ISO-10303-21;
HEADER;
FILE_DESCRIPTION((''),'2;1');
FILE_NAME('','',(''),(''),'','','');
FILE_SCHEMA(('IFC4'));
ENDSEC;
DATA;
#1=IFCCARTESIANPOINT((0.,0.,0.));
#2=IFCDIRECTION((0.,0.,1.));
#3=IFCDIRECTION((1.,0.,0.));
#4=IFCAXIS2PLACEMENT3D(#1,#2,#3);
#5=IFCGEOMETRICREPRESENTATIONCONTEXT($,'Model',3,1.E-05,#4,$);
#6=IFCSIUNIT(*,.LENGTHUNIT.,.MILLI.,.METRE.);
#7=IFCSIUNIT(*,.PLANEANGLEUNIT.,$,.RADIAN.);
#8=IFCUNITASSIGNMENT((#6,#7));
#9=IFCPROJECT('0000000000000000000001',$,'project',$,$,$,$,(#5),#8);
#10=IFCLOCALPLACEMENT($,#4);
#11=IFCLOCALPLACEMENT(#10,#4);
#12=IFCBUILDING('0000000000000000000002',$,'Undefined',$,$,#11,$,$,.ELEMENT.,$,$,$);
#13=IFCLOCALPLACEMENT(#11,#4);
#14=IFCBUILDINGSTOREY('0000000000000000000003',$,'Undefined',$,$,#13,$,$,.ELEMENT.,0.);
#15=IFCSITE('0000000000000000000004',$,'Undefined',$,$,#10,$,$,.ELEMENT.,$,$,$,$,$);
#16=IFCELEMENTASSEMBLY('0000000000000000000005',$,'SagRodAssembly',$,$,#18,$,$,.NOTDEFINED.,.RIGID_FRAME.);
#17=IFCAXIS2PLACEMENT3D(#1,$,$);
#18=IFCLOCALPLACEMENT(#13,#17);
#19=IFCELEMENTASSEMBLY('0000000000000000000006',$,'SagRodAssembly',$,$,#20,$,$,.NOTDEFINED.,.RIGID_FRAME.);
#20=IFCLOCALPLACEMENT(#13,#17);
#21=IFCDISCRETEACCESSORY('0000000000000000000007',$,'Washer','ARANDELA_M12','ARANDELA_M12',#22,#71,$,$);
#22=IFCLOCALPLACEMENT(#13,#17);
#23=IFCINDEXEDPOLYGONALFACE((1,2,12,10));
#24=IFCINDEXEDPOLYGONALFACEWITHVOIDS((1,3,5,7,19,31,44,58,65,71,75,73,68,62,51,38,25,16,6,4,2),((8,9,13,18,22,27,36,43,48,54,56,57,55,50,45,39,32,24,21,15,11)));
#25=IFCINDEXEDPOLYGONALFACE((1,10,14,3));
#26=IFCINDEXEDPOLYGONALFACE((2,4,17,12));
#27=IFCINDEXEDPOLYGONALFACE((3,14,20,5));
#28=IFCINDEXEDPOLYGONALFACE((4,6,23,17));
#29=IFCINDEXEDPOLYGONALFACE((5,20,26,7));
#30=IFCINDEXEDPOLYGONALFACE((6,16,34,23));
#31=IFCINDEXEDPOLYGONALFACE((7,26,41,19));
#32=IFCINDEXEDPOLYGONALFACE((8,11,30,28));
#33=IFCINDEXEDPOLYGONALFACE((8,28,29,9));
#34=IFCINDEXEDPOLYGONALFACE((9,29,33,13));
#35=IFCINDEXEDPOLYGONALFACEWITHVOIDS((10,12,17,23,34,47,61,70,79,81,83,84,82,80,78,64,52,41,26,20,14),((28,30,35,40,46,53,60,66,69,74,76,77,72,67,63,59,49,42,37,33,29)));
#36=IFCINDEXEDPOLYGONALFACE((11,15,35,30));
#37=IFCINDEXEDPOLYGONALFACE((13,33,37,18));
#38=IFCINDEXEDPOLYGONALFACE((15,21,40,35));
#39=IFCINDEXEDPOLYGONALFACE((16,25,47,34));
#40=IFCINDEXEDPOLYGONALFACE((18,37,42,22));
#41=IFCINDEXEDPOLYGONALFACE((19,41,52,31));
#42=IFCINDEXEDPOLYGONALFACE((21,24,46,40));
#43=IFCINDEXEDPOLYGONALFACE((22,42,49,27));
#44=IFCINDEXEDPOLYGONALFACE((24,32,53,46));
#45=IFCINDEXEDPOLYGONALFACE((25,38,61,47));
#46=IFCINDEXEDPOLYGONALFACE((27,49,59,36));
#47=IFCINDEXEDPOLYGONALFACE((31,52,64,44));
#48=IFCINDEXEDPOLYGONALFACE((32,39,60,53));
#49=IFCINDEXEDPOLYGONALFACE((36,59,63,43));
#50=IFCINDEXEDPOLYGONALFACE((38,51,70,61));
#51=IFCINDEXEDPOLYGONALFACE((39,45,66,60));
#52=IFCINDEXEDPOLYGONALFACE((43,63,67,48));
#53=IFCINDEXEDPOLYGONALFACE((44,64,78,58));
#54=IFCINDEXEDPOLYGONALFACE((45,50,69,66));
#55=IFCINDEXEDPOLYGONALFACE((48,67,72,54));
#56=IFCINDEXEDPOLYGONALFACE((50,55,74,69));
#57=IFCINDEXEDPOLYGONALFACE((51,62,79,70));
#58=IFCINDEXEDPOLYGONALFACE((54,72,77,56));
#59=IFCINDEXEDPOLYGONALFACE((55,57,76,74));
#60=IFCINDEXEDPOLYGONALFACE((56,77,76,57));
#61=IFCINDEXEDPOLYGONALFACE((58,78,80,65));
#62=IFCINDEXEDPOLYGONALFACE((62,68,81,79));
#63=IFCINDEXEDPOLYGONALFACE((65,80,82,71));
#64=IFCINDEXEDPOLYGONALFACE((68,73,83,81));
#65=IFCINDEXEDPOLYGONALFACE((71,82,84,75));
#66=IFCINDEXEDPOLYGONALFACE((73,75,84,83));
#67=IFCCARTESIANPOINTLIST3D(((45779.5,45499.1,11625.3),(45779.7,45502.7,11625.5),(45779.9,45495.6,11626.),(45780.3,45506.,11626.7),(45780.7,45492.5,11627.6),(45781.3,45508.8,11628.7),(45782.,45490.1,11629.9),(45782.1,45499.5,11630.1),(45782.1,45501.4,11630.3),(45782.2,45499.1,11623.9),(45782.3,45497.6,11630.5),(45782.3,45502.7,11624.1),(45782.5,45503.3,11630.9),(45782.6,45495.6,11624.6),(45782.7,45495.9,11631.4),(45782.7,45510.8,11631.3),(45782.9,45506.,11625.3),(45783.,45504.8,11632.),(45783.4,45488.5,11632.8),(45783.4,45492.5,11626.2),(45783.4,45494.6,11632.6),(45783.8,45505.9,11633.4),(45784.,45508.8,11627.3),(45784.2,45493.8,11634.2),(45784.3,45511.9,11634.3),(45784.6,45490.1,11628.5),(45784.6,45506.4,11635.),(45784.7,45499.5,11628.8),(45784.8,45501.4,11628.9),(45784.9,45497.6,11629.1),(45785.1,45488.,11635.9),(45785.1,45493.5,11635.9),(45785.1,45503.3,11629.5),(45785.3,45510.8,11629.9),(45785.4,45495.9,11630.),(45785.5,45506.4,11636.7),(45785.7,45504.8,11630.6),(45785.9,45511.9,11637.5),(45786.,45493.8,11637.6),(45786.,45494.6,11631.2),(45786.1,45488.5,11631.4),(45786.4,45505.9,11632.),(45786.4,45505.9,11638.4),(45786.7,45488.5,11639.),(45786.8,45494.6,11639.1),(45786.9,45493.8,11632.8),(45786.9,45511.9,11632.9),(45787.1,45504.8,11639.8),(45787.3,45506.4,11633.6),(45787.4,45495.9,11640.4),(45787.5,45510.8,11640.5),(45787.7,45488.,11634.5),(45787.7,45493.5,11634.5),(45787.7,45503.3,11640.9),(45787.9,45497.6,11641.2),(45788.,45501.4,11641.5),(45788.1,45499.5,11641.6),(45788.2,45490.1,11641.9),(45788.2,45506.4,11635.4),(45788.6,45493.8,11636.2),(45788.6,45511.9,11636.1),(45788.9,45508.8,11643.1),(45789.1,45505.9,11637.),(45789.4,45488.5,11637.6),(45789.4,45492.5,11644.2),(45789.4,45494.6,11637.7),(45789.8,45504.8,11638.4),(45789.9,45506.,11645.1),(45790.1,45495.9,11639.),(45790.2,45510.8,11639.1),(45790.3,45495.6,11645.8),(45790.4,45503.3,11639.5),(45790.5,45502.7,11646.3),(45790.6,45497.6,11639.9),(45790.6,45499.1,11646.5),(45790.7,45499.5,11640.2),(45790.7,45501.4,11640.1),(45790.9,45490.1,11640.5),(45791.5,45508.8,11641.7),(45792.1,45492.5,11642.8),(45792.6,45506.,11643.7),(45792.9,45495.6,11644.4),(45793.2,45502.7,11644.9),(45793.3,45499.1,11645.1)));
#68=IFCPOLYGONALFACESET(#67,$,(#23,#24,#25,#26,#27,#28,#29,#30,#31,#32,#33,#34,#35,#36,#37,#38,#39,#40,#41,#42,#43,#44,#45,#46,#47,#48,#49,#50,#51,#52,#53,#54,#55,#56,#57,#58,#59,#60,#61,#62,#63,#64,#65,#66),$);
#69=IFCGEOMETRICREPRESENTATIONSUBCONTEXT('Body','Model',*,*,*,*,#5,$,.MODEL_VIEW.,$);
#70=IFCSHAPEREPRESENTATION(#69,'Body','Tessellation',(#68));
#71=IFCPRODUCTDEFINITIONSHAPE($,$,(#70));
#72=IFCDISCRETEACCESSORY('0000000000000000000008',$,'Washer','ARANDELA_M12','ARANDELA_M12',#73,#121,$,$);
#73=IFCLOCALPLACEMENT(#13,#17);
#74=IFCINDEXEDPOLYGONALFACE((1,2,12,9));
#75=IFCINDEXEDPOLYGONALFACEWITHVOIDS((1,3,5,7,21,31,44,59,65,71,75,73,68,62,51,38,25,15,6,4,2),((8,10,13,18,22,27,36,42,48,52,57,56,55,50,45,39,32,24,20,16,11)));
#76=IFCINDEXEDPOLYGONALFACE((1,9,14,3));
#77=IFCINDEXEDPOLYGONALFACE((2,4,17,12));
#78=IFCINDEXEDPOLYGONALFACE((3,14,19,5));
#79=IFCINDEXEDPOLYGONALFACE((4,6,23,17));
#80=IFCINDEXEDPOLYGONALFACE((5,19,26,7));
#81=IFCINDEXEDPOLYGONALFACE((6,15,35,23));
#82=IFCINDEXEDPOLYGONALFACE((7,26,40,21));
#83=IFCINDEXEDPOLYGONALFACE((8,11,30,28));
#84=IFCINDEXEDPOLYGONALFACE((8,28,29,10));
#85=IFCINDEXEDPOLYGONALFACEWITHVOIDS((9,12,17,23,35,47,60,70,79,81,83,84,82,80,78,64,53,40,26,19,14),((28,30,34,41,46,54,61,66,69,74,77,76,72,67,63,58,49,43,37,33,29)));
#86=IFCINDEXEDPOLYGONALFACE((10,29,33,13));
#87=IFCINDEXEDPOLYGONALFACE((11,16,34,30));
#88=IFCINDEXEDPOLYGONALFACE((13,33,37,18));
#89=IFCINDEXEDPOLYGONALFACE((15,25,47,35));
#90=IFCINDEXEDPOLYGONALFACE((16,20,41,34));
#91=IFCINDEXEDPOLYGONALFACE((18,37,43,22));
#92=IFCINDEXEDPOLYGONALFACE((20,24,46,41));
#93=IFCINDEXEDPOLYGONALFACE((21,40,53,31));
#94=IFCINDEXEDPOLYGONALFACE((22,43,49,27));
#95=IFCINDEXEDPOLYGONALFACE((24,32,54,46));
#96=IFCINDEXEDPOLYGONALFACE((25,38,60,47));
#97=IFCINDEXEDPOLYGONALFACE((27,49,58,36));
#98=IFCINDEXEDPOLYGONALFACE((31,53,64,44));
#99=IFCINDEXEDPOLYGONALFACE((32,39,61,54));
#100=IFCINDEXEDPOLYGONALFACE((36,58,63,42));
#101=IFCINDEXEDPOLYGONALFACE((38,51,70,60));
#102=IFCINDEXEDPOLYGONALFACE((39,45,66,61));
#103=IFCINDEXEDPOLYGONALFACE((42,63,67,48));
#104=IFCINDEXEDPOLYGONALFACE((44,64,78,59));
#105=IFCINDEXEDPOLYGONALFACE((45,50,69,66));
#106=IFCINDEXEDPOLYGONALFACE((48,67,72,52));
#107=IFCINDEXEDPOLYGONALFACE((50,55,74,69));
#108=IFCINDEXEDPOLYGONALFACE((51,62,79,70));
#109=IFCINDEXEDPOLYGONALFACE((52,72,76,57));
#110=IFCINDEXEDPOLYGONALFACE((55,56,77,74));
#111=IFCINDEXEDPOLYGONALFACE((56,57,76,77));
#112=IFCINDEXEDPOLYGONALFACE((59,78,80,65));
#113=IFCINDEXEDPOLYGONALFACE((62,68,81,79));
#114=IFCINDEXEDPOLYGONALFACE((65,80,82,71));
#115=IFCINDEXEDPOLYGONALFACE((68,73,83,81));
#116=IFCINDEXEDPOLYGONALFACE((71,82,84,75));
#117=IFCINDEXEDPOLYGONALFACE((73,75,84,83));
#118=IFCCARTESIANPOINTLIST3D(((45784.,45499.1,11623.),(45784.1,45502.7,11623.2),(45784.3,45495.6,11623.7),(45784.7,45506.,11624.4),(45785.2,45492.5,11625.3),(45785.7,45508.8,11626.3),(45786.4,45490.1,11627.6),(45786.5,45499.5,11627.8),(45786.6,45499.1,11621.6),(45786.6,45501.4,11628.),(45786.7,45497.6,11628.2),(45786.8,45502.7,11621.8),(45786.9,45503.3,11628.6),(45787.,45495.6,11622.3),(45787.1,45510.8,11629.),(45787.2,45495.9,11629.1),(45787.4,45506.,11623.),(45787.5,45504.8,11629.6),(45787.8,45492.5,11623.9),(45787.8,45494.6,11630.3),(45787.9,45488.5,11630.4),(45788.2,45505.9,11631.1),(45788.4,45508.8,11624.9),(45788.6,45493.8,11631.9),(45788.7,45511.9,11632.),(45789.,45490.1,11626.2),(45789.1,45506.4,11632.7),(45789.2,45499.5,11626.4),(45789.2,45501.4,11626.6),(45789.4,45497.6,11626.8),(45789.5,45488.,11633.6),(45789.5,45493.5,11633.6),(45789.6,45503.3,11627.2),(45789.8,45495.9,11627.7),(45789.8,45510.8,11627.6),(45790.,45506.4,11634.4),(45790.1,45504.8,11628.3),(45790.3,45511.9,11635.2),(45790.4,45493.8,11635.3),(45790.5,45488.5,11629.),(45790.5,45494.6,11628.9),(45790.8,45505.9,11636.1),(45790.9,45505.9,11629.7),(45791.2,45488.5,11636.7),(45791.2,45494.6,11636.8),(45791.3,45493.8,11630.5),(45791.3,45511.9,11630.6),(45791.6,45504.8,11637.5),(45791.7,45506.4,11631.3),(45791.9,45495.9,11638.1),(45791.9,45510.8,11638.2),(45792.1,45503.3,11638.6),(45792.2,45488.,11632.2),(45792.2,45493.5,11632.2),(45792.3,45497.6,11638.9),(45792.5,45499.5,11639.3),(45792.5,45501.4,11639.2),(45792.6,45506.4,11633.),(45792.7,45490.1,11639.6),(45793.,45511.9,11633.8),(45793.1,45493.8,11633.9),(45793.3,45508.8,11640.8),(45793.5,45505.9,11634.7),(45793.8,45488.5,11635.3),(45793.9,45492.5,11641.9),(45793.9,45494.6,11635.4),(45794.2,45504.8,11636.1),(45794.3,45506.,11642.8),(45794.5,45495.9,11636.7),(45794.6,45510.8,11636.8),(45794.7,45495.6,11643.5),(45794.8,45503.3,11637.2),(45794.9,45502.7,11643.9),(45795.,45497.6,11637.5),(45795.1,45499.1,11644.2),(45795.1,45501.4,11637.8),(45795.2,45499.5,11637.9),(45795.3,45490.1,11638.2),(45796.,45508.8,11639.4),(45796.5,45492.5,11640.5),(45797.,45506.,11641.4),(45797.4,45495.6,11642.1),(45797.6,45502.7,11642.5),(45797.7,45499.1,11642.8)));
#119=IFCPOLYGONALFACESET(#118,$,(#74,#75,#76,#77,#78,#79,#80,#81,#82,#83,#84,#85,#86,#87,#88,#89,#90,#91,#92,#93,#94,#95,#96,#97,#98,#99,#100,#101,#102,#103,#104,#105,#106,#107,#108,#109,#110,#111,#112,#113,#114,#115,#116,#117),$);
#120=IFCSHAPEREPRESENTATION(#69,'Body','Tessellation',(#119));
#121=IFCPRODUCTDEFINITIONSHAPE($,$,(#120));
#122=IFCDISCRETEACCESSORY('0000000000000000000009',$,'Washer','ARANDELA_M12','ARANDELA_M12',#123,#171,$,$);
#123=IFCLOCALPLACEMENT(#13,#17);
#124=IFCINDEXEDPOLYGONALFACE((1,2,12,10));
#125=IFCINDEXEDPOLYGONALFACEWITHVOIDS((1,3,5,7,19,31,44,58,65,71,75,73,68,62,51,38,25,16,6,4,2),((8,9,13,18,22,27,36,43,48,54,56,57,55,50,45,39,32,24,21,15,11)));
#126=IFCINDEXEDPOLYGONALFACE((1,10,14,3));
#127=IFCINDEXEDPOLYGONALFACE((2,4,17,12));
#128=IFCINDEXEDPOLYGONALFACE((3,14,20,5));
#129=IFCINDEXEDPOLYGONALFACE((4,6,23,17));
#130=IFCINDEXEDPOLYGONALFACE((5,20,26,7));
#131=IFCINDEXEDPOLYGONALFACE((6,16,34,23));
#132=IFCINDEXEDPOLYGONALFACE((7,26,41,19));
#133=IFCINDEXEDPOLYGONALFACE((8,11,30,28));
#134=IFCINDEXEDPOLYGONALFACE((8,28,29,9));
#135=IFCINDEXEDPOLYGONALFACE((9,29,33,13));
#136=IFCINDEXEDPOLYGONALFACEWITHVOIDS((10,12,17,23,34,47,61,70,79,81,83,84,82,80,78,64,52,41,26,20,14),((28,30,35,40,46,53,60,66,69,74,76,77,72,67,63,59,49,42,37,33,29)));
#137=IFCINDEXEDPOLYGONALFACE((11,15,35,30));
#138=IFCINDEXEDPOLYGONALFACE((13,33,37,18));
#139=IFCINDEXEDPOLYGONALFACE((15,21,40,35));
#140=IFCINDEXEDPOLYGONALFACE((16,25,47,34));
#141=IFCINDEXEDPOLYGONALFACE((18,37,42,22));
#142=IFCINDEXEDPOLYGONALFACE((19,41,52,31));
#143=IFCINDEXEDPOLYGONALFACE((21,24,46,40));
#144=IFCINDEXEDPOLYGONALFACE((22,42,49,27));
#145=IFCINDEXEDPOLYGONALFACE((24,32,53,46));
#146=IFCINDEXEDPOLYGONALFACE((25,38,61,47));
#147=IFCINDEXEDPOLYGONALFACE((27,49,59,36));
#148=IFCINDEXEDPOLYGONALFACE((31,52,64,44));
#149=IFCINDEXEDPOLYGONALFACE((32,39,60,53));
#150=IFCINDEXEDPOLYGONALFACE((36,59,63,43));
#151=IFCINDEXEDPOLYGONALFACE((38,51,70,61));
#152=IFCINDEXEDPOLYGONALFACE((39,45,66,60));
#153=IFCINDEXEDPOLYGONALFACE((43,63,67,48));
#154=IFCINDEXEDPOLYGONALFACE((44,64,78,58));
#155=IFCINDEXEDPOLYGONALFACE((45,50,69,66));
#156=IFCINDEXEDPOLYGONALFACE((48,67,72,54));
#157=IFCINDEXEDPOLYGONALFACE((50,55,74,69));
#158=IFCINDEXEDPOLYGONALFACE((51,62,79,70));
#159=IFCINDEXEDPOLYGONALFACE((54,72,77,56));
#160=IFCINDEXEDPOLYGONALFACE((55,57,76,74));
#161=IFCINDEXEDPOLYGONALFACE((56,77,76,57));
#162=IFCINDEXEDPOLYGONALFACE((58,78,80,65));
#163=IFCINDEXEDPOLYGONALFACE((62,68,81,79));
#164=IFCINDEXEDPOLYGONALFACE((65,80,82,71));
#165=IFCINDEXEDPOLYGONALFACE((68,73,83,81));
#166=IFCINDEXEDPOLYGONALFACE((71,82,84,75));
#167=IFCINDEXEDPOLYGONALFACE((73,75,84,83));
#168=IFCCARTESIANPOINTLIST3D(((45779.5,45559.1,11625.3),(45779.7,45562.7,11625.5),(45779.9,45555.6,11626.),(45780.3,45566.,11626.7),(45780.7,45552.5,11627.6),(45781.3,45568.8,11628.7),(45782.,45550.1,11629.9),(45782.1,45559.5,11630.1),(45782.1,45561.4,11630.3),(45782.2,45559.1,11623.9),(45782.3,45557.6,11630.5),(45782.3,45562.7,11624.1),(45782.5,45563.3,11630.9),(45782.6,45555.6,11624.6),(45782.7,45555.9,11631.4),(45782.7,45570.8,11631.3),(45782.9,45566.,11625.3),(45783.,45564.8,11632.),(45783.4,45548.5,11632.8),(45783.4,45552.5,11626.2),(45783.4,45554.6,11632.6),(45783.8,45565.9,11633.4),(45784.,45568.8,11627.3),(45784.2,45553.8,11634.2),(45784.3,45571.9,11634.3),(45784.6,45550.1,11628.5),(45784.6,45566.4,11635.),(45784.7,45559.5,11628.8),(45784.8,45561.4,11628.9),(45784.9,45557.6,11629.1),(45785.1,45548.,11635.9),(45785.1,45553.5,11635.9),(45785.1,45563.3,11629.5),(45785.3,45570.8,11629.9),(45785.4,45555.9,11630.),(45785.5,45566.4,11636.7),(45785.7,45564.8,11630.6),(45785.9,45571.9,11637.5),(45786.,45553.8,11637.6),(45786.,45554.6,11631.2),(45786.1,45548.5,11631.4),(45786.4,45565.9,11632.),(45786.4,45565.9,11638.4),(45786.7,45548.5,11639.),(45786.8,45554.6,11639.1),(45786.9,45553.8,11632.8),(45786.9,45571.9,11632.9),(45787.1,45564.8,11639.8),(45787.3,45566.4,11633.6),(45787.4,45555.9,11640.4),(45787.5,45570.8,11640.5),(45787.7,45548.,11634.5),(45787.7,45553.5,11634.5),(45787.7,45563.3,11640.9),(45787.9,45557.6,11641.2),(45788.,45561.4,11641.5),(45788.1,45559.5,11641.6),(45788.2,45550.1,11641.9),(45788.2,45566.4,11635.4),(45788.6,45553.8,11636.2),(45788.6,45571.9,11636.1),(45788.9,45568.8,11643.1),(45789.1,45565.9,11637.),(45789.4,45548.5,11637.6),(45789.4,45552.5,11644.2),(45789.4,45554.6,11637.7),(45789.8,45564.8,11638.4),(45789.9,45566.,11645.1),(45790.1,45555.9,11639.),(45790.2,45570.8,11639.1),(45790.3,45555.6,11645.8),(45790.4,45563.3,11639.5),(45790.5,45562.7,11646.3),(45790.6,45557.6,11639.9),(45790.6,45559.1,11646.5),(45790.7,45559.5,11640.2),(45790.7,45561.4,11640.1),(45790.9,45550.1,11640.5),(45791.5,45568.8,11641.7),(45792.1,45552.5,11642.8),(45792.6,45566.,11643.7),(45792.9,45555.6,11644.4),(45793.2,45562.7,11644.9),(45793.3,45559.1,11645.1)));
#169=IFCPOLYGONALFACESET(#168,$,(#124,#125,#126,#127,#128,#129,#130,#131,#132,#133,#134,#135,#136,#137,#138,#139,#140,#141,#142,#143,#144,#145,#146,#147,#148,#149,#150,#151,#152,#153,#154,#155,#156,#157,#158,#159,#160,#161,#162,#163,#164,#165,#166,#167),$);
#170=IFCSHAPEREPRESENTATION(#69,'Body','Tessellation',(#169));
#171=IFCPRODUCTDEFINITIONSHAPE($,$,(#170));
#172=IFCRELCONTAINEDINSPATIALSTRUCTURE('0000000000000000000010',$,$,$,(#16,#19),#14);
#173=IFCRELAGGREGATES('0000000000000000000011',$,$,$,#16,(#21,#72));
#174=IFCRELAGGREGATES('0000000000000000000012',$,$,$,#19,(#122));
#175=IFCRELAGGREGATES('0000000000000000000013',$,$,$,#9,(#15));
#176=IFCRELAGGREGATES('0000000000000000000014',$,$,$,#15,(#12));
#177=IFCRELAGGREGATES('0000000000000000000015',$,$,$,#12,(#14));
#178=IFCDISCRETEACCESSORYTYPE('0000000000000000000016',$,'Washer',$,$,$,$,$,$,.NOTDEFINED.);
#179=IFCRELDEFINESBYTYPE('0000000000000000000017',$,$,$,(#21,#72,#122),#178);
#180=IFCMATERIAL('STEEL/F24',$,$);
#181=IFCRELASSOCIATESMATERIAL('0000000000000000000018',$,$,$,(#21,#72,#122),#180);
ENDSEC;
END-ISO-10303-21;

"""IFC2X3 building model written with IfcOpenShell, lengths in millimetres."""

from ifc_helpers import new_model, si_unit, frame, origin_with_axes, origin_2d_with_axis, place, context, subcontext, project, spatial, hollow_circle, extrude, material, type_object, element, aggregate, save


model = new_model("IFC2X3")

# Units and contexts
model_context = context("Model", 3, precision=1e-05, world=origin_with_axes())
body_context = subcontext(model_context, "Body", "Model", "MODEL_VIEW")
ifc_project = project(units=[si_unit("LENGTHUNIT", "METRE", prefix="MILLI"), si_unit("PLANEANGLEUNIT", "RADIAN")], contexts=[model_context])

# Site, building, storey
site_placement = place(None, origin_with_axes())
site = spatial("IfcSite", under=ifc_project, at=site_placement, Name="Undefined", CompositionType="ELEMENT")
building_placement = place(site_placement, origin_with_axes())
building = spatial("IfcBuilding", under=site, at=building_placement, Name="Undefined", CompositionType="ELEMENT")
storey_placement = place(building_placement, origin_with_axes())
storey = spatial("IfcBuildingStorey", under=building, at=storey_placement, Name="Undefined", CompositionType="ELEMENT", Elevation=0.0)

# Element assembly
ifc_material_1 = material(Name="STEEL/F24")
assembly_1_placement = place(storey_placement, origin_with_axes())
assembly_1 = element("IfcElementAssembly", 1, at=assembly_1_placement, inside=storey, Name="SagRodAssembly", AssemblyPlace="NOTDEFINED", PredefinedType="RIGID_FRAME")

# Element assembly
assembly_2_placement = place(storey_placement, origin_with_axes())
assembly_2 = element("IfcElementAssembly", 2, at=assembly_2_placement, inside=storey, Name="SagRodAssembly", AssemblyPlace="NOTDEFINED", PredefinedType="RIGID_FRAME")

# Discrete accessories
discrete_accessory_type_1 = type_object("IfcDiscreteAccessoryType", Name="Washer")
discrete_accessory_1_placement = place(assembly_1_placement, frame((45787.7, 45500.0, 11634.5), z_axis=(-0.463578, 0.0, -0.886056), x_axis=(-0.886056, 0.0, 0.463578)))
discrete_accessory_1 = element("IfcDiscreteAccessory", 3, at=discrete_accessory_1_placement, type_object=discrete_accessory_type_1, material=ifc_material_1, Name="Washer", Description="ARANDELA_M12", ObjectType="ARANDELA_M12", context=body_context, shape_type="SweptSolid", body=[
    extrude(hollow_circle(Radius=12.0, WallThickness=5.5, at=origin_2d_with_axis()), frame((3.0, 0.0, 0.0), z_axis=(-1.0, 0.0, 0.0), x_axis=(0.0, -1.0, 0.0)), (0.0, 0.0, 1.0), 3.0),
])
discrete_accessory_2_placement = place(assembly_1_placement, frame((45792.2, 45500.0, 11632.2), z_axis=(-0.463578, 0.0, -0.886056), x_axis=(-0.886056, 0.0, 0.463578)))
discrete_accessory_2 = element("IfcDiscreteAccessory", 4, at=discrete_accessory_2_placement, type_object=discrete_accessory_type_1, material=ifc_material_1, Name="Washer", Description="ARANDELA_M12", ObjectType="ARANDELA_M12", context=body_context, shape_type="SweptSolid", body=[
    extrude(hollow_circle(Radius=12.0, WallThickness=5.5, at=origin_2d_with_axis()), frame((3.0, 0.0, 0.0), z_axis=(-1.0, 0.0, 0.0), x_axis=(0.0, -1.0, 0.0)), (0.0, 0.0, 1.0), 3.0),
])
aggregate(assembly_1, [discrete_accessory_1, discrete_accessory_2])
discrete_accessory_3_placement = place(assembly_2_placement, frame((45787.7, 45560.0, 11634.5), z_axis=(-0.463578, 0.0, -0.886056), x_axis=(-0.886056, 0.0, 0.463578)))
discrete_accessory_3 = element("IfcDiscreteAccessory", 5, at=discrete_accessory_3_placement, type_object=discrete_accessory_type_1, material=ifc_material_1, Name="Washer", Description="ARANDELA_M12", ObjectType="ARANDELA_M12", context=body_context, shape_type="SweptSolid", body=[
    extrude(hollow_circle(Radius=12.0, WallThickness=5.5, at=origin_2d_with_axis()), frame((3.0, 0.0, 0.0), z_axis=(-1.0, 0.0, 0.0), x_axis=(0.0, -1.0, 0.0)), (0.0, 0.0, 1.0), 3.0),
])
aggregate(assembly_2, [discrete_accessory_3])

save(model, "model.ifc")
